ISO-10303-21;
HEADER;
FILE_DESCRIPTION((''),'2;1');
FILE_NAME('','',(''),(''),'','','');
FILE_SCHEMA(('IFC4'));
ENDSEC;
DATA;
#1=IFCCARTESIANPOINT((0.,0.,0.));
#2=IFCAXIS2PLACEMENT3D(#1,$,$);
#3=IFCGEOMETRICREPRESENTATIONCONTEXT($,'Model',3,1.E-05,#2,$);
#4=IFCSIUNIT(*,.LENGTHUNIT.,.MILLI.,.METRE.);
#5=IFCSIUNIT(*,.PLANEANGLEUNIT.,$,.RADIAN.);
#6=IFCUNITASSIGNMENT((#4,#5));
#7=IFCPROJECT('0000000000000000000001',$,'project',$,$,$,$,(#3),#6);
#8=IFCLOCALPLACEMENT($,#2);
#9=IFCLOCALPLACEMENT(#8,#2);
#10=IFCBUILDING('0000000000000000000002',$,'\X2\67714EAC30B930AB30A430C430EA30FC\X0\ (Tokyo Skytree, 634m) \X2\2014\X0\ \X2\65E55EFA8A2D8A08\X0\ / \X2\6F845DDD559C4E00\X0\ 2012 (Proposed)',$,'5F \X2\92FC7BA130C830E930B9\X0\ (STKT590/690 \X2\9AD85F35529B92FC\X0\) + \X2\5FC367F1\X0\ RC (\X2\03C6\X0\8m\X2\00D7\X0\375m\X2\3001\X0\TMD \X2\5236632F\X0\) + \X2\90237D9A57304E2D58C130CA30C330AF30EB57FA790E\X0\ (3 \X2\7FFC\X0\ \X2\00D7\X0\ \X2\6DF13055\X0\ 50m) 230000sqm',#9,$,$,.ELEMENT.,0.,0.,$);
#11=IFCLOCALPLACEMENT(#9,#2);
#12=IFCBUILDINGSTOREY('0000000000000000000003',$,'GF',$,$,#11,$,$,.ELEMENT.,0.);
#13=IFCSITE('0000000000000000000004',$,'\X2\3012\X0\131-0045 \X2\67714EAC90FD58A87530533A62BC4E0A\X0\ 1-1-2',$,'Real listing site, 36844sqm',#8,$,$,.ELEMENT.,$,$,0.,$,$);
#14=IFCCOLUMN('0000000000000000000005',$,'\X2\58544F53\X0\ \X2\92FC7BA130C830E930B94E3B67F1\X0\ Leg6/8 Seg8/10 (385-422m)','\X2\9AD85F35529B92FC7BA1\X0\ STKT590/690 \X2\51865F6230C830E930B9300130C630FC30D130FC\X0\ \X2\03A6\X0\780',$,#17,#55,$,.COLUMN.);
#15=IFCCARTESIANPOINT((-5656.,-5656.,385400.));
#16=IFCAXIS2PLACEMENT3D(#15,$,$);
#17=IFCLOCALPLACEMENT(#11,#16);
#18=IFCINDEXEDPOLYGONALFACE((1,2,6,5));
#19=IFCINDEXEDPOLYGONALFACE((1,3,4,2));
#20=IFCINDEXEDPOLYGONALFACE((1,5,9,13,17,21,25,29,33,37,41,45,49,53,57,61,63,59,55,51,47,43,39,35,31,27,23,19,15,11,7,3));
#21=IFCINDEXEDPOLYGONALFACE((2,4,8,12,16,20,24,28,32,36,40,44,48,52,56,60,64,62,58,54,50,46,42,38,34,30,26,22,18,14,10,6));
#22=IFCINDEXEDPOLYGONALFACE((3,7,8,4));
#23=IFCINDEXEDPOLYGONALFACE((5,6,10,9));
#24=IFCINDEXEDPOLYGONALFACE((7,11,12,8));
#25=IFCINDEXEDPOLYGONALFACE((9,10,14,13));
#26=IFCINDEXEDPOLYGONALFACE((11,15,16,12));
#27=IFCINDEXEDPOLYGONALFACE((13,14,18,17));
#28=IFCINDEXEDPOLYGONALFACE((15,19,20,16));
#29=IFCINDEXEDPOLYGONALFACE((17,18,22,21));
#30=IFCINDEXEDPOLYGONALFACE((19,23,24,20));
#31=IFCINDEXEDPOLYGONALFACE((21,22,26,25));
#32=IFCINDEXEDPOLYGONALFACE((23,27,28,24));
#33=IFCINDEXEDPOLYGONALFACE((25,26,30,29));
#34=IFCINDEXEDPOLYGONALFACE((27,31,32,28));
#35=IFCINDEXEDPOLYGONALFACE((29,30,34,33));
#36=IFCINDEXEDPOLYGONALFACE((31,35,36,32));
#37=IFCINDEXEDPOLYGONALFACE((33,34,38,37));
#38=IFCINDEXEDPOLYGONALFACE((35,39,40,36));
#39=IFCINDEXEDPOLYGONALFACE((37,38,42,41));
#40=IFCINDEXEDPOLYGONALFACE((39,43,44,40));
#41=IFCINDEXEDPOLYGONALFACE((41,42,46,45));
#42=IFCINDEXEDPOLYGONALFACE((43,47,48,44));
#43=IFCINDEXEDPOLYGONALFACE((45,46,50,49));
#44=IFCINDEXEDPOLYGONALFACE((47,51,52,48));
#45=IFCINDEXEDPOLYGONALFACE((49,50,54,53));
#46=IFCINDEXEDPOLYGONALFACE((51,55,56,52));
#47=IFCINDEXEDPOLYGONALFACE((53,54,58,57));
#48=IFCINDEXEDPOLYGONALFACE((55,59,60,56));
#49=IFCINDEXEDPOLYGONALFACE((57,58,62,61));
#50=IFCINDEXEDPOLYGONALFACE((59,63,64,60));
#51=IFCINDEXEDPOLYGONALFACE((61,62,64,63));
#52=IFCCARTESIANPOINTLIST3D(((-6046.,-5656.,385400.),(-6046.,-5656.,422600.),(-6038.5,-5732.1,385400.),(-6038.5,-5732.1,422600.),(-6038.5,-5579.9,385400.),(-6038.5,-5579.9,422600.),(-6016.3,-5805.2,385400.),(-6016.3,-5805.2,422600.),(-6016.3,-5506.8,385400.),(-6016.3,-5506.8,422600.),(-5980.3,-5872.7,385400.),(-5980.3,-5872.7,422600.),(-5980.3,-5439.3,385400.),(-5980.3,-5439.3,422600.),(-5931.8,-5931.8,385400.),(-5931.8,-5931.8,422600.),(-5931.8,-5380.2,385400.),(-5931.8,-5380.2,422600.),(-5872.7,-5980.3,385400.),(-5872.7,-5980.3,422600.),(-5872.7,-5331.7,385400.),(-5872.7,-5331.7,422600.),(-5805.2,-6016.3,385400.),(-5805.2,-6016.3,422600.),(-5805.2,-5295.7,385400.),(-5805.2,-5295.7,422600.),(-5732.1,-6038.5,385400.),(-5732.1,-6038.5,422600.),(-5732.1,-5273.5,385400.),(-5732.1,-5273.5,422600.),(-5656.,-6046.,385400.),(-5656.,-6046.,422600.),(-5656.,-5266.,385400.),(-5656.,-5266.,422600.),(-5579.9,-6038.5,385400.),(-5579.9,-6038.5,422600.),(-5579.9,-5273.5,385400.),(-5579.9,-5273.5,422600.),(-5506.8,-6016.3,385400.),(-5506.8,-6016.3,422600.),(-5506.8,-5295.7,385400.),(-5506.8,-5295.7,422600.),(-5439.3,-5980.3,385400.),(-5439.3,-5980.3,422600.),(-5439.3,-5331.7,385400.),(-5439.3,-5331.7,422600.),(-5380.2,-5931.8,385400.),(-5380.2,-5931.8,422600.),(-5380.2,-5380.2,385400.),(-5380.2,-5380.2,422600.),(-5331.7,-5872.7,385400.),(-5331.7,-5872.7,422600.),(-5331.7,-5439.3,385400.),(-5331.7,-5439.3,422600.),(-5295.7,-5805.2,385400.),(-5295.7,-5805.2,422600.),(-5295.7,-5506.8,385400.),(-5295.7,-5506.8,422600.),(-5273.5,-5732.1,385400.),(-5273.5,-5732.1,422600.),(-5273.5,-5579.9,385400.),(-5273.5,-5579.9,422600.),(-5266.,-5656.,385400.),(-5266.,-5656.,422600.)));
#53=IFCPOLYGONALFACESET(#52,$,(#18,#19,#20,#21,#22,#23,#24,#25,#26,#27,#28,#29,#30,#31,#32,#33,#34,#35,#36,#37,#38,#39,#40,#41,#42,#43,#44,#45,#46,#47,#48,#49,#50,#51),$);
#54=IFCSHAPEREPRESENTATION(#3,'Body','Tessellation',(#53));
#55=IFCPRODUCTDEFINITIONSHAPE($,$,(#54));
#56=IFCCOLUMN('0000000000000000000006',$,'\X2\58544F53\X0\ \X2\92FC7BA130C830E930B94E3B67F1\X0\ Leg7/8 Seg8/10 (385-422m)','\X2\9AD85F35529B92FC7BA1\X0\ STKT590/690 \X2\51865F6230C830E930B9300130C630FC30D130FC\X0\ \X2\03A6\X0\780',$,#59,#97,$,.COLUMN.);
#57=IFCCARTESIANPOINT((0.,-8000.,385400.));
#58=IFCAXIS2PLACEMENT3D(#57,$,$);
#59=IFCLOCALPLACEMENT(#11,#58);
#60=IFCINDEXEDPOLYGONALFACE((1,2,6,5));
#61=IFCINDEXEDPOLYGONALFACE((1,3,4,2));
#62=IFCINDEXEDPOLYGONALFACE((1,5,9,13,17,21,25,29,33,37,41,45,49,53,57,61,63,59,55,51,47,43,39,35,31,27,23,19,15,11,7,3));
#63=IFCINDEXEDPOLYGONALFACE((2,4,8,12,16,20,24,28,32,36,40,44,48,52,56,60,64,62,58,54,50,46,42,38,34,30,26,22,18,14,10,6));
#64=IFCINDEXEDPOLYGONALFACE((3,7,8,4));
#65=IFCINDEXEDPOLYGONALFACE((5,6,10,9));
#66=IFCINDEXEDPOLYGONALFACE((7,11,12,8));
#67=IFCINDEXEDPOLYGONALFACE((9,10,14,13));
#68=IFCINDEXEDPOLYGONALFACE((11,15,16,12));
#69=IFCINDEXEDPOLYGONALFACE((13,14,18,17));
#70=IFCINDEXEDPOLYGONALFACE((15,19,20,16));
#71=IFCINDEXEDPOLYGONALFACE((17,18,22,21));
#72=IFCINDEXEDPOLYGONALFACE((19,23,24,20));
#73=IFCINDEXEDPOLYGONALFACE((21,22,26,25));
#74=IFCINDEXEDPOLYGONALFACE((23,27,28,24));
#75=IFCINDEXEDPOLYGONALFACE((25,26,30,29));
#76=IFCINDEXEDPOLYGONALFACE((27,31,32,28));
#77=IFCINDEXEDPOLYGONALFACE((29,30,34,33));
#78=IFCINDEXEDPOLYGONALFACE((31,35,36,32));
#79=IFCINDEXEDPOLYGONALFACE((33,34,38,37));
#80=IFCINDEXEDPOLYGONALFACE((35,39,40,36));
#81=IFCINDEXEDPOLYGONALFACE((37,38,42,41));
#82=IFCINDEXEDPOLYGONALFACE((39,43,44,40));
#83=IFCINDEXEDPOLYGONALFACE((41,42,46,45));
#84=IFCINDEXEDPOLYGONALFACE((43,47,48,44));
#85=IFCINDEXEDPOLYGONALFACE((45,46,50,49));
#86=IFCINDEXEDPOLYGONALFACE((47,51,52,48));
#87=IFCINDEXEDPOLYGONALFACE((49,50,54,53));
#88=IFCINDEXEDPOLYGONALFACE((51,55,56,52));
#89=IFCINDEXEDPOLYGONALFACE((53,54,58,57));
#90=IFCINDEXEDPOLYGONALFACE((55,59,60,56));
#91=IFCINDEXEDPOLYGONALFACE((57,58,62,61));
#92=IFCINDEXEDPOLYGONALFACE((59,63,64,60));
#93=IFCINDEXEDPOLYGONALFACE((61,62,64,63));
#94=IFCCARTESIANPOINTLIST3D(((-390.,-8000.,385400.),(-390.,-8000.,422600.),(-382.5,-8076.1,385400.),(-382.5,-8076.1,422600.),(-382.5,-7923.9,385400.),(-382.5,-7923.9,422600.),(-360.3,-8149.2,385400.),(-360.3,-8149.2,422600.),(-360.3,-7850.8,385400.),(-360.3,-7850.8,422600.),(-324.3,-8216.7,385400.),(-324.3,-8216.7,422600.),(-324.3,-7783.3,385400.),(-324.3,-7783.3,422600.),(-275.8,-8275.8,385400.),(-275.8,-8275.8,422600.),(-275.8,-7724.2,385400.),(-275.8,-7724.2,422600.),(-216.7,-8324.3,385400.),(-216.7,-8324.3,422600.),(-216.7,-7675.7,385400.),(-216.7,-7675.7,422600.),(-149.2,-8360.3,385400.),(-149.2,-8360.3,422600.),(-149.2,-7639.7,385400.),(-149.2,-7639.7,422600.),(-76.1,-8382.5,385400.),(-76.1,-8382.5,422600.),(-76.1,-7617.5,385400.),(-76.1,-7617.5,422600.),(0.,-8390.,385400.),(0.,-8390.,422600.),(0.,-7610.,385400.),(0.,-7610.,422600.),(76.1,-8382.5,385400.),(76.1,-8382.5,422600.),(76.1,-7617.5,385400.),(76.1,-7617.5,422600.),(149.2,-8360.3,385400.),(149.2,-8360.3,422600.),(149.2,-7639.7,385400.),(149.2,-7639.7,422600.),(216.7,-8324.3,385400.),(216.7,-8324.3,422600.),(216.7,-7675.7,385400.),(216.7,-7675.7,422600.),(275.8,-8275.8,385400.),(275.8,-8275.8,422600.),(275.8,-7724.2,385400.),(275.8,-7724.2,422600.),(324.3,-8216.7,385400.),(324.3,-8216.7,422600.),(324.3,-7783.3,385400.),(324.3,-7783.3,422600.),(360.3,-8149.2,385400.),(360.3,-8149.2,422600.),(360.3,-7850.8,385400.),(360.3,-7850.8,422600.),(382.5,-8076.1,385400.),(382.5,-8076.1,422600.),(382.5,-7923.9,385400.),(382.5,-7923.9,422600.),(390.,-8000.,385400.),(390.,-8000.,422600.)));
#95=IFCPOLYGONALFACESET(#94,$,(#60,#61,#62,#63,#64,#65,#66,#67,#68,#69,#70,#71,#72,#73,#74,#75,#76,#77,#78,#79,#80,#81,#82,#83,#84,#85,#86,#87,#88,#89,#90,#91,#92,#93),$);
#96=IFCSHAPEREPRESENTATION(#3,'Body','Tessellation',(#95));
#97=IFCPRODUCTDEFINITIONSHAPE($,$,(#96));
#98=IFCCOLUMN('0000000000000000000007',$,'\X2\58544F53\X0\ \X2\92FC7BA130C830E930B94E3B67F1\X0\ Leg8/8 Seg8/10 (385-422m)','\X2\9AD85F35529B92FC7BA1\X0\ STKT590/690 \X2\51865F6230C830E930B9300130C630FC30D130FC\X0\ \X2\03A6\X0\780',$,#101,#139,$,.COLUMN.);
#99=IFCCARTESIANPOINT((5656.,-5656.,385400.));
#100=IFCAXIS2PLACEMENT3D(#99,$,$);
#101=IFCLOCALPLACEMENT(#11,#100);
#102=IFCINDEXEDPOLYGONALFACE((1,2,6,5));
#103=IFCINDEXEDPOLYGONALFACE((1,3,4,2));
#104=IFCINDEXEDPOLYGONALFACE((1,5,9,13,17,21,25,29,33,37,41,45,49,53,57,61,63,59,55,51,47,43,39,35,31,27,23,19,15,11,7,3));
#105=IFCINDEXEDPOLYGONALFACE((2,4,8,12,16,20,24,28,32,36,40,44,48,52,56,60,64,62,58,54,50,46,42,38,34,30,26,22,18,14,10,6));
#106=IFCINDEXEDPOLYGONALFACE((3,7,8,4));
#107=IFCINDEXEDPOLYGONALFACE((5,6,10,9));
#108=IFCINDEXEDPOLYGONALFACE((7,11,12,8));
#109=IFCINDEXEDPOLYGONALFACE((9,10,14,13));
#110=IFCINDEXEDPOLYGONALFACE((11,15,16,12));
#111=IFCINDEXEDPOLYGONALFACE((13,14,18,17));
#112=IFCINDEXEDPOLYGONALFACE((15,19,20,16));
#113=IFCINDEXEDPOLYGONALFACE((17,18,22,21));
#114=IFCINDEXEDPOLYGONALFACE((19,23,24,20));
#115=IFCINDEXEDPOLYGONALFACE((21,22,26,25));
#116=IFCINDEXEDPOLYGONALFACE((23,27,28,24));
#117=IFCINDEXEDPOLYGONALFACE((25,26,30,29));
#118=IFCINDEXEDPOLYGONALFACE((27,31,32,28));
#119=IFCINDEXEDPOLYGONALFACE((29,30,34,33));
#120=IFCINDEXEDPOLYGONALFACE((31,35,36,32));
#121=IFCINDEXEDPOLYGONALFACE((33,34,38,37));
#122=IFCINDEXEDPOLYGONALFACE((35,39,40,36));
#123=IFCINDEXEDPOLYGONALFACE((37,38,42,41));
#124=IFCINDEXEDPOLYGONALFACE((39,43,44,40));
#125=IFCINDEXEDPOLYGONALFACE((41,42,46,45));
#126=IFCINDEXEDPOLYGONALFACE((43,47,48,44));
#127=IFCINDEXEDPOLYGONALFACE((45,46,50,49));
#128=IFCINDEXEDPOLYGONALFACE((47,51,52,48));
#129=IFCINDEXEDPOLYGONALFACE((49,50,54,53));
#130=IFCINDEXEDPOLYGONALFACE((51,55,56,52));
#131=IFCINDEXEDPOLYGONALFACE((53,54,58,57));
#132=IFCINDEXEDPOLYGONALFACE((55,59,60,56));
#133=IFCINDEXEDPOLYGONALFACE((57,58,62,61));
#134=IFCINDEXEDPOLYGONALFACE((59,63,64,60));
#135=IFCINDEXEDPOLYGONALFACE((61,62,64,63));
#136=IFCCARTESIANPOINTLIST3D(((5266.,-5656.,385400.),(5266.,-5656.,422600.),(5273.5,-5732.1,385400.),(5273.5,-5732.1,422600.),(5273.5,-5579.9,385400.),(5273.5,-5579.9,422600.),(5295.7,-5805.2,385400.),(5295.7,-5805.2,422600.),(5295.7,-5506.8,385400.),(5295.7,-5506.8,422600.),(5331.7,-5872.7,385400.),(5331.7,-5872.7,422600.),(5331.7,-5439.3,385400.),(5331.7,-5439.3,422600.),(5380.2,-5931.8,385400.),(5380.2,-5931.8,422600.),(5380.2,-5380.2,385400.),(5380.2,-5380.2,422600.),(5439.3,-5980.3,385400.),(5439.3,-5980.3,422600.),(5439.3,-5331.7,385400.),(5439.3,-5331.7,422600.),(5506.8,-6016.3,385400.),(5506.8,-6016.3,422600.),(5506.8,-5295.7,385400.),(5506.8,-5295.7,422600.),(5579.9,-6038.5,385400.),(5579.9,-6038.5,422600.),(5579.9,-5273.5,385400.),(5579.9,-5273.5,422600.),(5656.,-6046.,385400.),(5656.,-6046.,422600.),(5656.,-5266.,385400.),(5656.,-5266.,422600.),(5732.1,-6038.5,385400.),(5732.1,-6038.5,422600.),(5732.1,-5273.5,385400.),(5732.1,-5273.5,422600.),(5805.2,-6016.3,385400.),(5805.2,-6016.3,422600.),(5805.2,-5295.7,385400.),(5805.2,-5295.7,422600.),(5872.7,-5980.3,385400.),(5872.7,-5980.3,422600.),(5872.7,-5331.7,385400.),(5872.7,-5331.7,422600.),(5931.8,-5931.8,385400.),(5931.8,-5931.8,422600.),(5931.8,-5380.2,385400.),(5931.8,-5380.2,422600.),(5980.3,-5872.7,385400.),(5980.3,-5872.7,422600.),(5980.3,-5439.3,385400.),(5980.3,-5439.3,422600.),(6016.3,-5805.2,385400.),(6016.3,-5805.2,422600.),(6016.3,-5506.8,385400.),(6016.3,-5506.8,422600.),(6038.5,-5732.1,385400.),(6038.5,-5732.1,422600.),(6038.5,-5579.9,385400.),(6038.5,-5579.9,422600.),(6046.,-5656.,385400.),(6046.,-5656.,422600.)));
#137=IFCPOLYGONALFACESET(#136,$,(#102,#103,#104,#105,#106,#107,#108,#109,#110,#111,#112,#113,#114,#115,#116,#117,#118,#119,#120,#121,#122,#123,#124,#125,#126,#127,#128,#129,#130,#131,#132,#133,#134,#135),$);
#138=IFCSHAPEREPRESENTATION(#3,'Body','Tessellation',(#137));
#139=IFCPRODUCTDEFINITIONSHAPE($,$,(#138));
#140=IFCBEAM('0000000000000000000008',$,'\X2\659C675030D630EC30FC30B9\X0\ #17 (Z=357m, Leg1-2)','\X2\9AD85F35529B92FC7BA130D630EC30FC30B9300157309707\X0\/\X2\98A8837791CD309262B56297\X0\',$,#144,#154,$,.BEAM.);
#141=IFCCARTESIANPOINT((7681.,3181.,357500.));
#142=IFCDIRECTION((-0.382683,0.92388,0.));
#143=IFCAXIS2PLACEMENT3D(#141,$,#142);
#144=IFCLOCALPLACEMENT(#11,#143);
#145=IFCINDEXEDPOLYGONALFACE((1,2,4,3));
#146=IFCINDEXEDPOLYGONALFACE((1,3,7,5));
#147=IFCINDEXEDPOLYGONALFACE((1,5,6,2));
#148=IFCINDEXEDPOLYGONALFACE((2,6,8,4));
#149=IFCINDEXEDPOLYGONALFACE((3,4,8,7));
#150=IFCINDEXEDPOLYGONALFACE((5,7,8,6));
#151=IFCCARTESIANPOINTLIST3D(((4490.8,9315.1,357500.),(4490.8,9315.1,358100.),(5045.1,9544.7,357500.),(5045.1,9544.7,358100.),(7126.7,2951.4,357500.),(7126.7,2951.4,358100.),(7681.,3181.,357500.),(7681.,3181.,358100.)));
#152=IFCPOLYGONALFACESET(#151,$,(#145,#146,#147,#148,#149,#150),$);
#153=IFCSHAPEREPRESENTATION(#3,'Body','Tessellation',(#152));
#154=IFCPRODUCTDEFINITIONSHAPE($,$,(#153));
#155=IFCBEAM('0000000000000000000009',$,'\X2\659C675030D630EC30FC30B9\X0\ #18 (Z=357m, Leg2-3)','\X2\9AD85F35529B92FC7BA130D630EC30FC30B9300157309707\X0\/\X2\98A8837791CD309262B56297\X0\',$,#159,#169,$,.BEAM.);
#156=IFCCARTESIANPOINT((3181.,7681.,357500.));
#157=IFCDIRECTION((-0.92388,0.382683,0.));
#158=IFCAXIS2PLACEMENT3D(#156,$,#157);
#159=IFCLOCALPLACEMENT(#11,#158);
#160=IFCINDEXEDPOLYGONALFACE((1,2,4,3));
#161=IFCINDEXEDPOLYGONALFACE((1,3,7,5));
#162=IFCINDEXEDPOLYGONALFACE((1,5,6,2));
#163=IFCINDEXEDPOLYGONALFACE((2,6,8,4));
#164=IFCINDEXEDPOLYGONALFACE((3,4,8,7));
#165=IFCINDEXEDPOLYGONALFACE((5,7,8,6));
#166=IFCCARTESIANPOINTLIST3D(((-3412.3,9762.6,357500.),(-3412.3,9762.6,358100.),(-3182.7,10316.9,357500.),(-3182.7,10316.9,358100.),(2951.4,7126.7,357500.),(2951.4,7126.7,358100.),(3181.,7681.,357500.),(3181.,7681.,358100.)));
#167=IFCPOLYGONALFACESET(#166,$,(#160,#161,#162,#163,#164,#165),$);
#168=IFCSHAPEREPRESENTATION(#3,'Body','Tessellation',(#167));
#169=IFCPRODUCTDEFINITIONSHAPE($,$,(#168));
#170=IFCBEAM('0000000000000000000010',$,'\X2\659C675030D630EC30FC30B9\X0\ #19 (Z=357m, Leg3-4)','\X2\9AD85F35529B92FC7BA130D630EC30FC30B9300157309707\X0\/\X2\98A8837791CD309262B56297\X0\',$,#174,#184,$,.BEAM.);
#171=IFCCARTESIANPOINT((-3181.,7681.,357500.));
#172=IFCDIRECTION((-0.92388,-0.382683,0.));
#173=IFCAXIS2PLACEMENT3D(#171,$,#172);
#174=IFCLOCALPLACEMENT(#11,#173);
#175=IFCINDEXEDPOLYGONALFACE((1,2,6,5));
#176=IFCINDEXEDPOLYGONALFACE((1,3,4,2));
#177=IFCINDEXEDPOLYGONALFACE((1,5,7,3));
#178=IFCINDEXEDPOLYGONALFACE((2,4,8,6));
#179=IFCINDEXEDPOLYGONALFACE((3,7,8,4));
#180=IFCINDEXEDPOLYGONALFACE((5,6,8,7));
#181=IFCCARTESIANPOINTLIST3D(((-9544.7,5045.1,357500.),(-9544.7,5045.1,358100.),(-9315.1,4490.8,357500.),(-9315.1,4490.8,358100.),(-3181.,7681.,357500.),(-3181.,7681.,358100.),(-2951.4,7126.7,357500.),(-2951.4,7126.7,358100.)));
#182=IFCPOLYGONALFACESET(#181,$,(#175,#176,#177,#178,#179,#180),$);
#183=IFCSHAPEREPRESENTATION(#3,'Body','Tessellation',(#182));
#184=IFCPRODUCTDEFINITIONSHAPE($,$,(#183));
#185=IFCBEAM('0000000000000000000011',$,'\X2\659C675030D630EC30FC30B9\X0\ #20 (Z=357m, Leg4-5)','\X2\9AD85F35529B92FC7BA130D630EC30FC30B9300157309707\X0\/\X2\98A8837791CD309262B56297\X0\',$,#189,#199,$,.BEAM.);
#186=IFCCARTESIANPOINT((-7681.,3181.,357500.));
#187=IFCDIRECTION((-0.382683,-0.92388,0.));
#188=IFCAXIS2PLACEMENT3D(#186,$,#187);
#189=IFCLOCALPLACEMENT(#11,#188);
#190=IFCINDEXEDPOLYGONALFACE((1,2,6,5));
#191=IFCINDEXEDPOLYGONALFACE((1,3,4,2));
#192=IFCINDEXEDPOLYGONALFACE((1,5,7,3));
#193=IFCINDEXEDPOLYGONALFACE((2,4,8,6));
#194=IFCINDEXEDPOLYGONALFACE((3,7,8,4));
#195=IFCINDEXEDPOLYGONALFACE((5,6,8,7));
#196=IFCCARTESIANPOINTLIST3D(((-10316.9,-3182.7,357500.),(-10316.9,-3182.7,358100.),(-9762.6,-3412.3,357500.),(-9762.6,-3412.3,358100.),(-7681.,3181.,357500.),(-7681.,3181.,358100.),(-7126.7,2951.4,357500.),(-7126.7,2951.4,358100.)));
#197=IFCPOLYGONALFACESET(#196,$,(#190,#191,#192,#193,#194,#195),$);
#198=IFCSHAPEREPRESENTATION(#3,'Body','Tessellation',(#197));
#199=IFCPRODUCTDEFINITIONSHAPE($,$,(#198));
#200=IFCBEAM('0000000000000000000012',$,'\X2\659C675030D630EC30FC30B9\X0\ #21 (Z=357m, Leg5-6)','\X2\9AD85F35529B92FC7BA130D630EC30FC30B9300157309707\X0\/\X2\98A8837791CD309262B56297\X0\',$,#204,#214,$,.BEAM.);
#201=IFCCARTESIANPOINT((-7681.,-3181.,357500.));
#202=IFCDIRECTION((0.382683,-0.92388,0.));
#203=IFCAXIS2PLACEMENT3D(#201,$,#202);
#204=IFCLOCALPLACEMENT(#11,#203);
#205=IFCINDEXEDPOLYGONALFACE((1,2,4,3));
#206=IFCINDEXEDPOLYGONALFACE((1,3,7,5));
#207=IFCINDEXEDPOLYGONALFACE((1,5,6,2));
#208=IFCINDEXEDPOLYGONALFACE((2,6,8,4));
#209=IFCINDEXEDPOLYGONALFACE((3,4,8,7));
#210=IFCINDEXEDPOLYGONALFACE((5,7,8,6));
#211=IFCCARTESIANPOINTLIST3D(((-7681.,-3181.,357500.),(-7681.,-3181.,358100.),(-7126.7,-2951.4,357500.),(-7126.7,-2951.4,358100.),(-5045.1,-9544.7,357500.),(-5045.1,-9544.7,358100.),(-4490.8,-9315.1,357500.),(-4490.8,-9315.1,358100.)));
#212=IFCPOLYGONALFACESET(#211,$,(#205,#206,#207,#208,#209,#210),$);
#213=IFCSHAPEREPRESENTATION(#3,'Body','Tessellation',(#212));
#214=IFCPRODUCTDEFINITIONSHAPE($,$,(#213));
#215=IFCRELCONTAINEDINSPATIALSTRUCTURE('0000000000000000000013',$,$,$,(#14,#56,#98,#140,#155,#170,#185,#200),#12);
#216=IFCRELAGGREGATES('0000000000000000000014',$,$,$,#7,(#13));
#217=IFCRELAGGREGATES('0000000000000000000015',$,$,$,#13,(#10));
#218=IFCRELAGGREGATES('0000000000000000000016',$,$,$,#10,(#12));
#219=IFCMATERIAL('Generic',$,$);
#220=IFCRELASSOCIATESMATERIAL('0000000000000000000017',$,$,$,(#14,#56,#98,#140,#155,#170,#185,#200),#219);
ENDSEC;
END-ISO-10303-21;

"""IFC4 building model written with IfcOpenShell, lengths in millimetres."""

from ifc_helpers import new_model, si_unit, frame, frame_2d, origin, origin_2d, place, context, project, spatial, rectangle, circle, extrude, material, element, save


model = new_model("IFC4")

# Units and contexts
model_context = context("Model", 3, precision=1e-05, world=origin())
ifc_project = project(units=[si_unit("LENGTHUNIT", "METRE", prefix="MILLI"), si_unit("PLANEANGLEUNIT", "RADIAN")], contexts=[model_context])

# Site, building, storey
site_placement = place(None, origin())
site = spatial("IfcSite", under=ifc_project, at=site_placement, Name="〒131-0045 東京都墨田区押上 1-1-2", ObjectType="Real listing site, 36844sqm", CompositionType="ELEMENT", RefElevation=0.0)
building_placement = place(site_placement, origin())
building = spatial("IfcBuilding", under=site, at=building_placement, Name="東京スカイツリー (Tokyo Skytree, 634m) — 日建設計 / 澄川喜一 2012 (Proposed)", ObjectType="5F 鋼管トラス (STKT590/690 高張力鋼) + 心柱 RC (φ8m×375m、TMD 制振) + 連続地中壁ナックル基礎 (3 翼 × 深さ 50m) 230000sqm", CompositionType="ELEMENT", ElevationOfRefHeight=0.0, ElevationOfTerrain=0.0)
storey_placement = place(building_placement, origin())
storey = spatial("IfcBuildingStorey", under=building, at=storey_placement, Name="GF", CompositionType="ELEMENT", Elevation=0.0)

# Columns
ifc_material_1 = material(Name="Generic")
column_1_placement = place(storey_placement, frame((-5656.0, -5656.0, 385400.0)))
element("IfcColumn", 1, at=column_1_placement, inside=storey, material=ifc_material_1, Name="塔体 鋼管トラス主柱 Leg6/8 Seg8/10 (385-422m)", Description="高張力鋼管 STKT590/690 円形トラス、テーパー Φ780", PredefinedType="COLUMN", context=model_context, shape_type="SweptSolid", body=[
    extrude(circle(Radius=390.0, at=origin_2d()), frame((-5656.0, -5656.0, 385400.0)), (0.0, 0.0, 1.0), 37200.0),
])
column_2_placement = place(storey_placement, frame((0.0, -8000.0, 385400.0)))
element("IfcColumn", 2, at=column_2_placement, inside=storey, material=ifc_material_1, Name="塔体 鋼管トラス主柱 Leg7/8 Seg8/10 (385-422m)", Description="高張力鋼管 STKT590/690 円形トラス、テーパー Φ780", PredefinedType="COLUMN", context=model_context, shape_type="SweptSolid", body=[
    extrude(circle(Radius=390.0, at=origin_2d()), frame((0.0, -8000.0, 385400.0)), (0.0, 0.0, 1.0), 37200.0),
])
column_3_placement = place(storey_placement, frame((5656.0, -5656.0, 385400.0)))
element("IfcColumn", 3, at=column_3_placement, inside=storey, material=ifc_material_1, Name="塔体 鋼管トラス主柱 Leg8/8 Seg8/10 (385-422m)", Description="高張力鋼管 STKT590/690 円形トラス、テーパー Φ780", PredefinedType="COLUMN", context=model_context, shape_type="SweptSolid", body=[
    extrude(circle(Radius=390.0, at=origin_2d()), frame((5656.0, -5656.0, 385400.0)), (0.0, 0.0, 1.0), 37200.0),
])

# Beams
beam_1_placement = place(storey_placement, frame((7681.0, 3181.0, 357500.0), x_axis=(-0.382683, 0.92388, 0.0)))
element("IfcBeam", 4, at=beam_1_placement, inside=storey, material=ifc_material_1, Name="斜材ブレース #17 (Z=357m, Leg1-2)", Description="高張力鋼管ブレース、地震/風荷重を抵抗", PredefinedType="BEAM", context=model_context, shape_type="SweptSolid", body=[
    extrude(rectangle(XDim=6888.0, YDim=600.0, at=frame_2d((3444.0, 300.0))), frame((7681.0, 3181.0, 357500.0), x_axis=(-0.382683, 0.92388, 0.0)), (0.0, 0.0, 1.0), 600.0),
])
beam_2_placement = place(storey_placement, frame((3181.0, 7681.0, 357500.0), x_axis=(-0.92388, 0.382683, 0.0)))
element("IfcBeam", 5, at=beam_2_placement, inside=storey, material=ifc_material_1, Name="斜材ブレース #18 (Z=357m, Leg2-3)", Description="高張力鋼管ブレース、地震/風荷重を抵抗", PredefinedType="BEAM", context=model_context, shape_type="SweptSolid", body=[
    extrude(rectangle(XDim=6888.0, YDim=600.0, at=frame_2d((3444.0, 300.0))), frame((3181.0, 7681.0, 357500.0), x_axis=(-0.92388, 0.382683, 0.0)), (0.0, 0.0, 1.0), 600.0),
])
beam_3_placement = place(storey_placement, frame((-3181.0, 7681.0, 357500.0), x_axis=(-0.92388, -0.382683, 0.0)))
element("IfcBeam", 6, at=beam_3_placement, inside=storey, material=ifc_material_1, Name="斜材ブレース #19 (Z=357m, Leg3-4)", Description="高張力鋼管ブレース、地震/風荷重を抵抗", PredefinedType="BEAM", context=model_context, shape_type="SweptSolid", body=[
    extrude(rectangle(XDim=6888.0, YDim=600.0, at=frame_2d((3444.0, 300.0))), frame((-3181.0, 7681.0, 357500.0), x_axis=(-0.92388, -0.382683, 0.0)), (0.0, 0.0, 1.0), 600.0),
])
beam_4_placement = place(storey_placement, frame((-7681.0, 3181.0, 357500.0), x_axis=(-0.382683, -0.92388, 0.0)))
element("IfcBeam", 7, at=beam_4_placement, inside=storey, material=ifc_material_1, Name="斜材ブレース #20 (Z=357m, Leg4-5)", Description="高張力鋼管ブレース、地震/風荷重を抵抗", PredefinedType="BEAM", context=model_context, shape_type="SweptSolid", body=[
    extrude(rectangle(XDim=6888.0, YDim=600.0, at=frame_2d((3444.0, 300.0))), frame((-7681.0, 3181.0, 357500.0), x_axis=(-0.382683, -0.92388, 0.0)), (0.0, 0.0, 1.0), 600.0),
])
beam_5_placement = place(storey_placement, frame((-7681.0, -3181.0, 357500.0), x_axis=(0.382683, -0.92388, 0.0)))
element("IfcBeam", 8, at=beam_5_placement, inside=storey, material=ifc_material_1, Name="斜材ブレース #21 (Z=357m, Leg5-6)", Description="高張力鋼管ブレース、地震/風荷重を抵抗", PredefinedType="BEAM", context=model_context, shape_type="SweptSolid", body=[
    extrude(rectangle(XDim=6888.0, YDim=600.0, at=frame_2d((3444.0, 300.0))), frame((-7681.0, -3181.0, 357500.0), x_axis=(0.382683, -0.92388, 0.0)), (0.0, 0.0, 1.0), 600.0),
])

save(model, "model.ifc")
